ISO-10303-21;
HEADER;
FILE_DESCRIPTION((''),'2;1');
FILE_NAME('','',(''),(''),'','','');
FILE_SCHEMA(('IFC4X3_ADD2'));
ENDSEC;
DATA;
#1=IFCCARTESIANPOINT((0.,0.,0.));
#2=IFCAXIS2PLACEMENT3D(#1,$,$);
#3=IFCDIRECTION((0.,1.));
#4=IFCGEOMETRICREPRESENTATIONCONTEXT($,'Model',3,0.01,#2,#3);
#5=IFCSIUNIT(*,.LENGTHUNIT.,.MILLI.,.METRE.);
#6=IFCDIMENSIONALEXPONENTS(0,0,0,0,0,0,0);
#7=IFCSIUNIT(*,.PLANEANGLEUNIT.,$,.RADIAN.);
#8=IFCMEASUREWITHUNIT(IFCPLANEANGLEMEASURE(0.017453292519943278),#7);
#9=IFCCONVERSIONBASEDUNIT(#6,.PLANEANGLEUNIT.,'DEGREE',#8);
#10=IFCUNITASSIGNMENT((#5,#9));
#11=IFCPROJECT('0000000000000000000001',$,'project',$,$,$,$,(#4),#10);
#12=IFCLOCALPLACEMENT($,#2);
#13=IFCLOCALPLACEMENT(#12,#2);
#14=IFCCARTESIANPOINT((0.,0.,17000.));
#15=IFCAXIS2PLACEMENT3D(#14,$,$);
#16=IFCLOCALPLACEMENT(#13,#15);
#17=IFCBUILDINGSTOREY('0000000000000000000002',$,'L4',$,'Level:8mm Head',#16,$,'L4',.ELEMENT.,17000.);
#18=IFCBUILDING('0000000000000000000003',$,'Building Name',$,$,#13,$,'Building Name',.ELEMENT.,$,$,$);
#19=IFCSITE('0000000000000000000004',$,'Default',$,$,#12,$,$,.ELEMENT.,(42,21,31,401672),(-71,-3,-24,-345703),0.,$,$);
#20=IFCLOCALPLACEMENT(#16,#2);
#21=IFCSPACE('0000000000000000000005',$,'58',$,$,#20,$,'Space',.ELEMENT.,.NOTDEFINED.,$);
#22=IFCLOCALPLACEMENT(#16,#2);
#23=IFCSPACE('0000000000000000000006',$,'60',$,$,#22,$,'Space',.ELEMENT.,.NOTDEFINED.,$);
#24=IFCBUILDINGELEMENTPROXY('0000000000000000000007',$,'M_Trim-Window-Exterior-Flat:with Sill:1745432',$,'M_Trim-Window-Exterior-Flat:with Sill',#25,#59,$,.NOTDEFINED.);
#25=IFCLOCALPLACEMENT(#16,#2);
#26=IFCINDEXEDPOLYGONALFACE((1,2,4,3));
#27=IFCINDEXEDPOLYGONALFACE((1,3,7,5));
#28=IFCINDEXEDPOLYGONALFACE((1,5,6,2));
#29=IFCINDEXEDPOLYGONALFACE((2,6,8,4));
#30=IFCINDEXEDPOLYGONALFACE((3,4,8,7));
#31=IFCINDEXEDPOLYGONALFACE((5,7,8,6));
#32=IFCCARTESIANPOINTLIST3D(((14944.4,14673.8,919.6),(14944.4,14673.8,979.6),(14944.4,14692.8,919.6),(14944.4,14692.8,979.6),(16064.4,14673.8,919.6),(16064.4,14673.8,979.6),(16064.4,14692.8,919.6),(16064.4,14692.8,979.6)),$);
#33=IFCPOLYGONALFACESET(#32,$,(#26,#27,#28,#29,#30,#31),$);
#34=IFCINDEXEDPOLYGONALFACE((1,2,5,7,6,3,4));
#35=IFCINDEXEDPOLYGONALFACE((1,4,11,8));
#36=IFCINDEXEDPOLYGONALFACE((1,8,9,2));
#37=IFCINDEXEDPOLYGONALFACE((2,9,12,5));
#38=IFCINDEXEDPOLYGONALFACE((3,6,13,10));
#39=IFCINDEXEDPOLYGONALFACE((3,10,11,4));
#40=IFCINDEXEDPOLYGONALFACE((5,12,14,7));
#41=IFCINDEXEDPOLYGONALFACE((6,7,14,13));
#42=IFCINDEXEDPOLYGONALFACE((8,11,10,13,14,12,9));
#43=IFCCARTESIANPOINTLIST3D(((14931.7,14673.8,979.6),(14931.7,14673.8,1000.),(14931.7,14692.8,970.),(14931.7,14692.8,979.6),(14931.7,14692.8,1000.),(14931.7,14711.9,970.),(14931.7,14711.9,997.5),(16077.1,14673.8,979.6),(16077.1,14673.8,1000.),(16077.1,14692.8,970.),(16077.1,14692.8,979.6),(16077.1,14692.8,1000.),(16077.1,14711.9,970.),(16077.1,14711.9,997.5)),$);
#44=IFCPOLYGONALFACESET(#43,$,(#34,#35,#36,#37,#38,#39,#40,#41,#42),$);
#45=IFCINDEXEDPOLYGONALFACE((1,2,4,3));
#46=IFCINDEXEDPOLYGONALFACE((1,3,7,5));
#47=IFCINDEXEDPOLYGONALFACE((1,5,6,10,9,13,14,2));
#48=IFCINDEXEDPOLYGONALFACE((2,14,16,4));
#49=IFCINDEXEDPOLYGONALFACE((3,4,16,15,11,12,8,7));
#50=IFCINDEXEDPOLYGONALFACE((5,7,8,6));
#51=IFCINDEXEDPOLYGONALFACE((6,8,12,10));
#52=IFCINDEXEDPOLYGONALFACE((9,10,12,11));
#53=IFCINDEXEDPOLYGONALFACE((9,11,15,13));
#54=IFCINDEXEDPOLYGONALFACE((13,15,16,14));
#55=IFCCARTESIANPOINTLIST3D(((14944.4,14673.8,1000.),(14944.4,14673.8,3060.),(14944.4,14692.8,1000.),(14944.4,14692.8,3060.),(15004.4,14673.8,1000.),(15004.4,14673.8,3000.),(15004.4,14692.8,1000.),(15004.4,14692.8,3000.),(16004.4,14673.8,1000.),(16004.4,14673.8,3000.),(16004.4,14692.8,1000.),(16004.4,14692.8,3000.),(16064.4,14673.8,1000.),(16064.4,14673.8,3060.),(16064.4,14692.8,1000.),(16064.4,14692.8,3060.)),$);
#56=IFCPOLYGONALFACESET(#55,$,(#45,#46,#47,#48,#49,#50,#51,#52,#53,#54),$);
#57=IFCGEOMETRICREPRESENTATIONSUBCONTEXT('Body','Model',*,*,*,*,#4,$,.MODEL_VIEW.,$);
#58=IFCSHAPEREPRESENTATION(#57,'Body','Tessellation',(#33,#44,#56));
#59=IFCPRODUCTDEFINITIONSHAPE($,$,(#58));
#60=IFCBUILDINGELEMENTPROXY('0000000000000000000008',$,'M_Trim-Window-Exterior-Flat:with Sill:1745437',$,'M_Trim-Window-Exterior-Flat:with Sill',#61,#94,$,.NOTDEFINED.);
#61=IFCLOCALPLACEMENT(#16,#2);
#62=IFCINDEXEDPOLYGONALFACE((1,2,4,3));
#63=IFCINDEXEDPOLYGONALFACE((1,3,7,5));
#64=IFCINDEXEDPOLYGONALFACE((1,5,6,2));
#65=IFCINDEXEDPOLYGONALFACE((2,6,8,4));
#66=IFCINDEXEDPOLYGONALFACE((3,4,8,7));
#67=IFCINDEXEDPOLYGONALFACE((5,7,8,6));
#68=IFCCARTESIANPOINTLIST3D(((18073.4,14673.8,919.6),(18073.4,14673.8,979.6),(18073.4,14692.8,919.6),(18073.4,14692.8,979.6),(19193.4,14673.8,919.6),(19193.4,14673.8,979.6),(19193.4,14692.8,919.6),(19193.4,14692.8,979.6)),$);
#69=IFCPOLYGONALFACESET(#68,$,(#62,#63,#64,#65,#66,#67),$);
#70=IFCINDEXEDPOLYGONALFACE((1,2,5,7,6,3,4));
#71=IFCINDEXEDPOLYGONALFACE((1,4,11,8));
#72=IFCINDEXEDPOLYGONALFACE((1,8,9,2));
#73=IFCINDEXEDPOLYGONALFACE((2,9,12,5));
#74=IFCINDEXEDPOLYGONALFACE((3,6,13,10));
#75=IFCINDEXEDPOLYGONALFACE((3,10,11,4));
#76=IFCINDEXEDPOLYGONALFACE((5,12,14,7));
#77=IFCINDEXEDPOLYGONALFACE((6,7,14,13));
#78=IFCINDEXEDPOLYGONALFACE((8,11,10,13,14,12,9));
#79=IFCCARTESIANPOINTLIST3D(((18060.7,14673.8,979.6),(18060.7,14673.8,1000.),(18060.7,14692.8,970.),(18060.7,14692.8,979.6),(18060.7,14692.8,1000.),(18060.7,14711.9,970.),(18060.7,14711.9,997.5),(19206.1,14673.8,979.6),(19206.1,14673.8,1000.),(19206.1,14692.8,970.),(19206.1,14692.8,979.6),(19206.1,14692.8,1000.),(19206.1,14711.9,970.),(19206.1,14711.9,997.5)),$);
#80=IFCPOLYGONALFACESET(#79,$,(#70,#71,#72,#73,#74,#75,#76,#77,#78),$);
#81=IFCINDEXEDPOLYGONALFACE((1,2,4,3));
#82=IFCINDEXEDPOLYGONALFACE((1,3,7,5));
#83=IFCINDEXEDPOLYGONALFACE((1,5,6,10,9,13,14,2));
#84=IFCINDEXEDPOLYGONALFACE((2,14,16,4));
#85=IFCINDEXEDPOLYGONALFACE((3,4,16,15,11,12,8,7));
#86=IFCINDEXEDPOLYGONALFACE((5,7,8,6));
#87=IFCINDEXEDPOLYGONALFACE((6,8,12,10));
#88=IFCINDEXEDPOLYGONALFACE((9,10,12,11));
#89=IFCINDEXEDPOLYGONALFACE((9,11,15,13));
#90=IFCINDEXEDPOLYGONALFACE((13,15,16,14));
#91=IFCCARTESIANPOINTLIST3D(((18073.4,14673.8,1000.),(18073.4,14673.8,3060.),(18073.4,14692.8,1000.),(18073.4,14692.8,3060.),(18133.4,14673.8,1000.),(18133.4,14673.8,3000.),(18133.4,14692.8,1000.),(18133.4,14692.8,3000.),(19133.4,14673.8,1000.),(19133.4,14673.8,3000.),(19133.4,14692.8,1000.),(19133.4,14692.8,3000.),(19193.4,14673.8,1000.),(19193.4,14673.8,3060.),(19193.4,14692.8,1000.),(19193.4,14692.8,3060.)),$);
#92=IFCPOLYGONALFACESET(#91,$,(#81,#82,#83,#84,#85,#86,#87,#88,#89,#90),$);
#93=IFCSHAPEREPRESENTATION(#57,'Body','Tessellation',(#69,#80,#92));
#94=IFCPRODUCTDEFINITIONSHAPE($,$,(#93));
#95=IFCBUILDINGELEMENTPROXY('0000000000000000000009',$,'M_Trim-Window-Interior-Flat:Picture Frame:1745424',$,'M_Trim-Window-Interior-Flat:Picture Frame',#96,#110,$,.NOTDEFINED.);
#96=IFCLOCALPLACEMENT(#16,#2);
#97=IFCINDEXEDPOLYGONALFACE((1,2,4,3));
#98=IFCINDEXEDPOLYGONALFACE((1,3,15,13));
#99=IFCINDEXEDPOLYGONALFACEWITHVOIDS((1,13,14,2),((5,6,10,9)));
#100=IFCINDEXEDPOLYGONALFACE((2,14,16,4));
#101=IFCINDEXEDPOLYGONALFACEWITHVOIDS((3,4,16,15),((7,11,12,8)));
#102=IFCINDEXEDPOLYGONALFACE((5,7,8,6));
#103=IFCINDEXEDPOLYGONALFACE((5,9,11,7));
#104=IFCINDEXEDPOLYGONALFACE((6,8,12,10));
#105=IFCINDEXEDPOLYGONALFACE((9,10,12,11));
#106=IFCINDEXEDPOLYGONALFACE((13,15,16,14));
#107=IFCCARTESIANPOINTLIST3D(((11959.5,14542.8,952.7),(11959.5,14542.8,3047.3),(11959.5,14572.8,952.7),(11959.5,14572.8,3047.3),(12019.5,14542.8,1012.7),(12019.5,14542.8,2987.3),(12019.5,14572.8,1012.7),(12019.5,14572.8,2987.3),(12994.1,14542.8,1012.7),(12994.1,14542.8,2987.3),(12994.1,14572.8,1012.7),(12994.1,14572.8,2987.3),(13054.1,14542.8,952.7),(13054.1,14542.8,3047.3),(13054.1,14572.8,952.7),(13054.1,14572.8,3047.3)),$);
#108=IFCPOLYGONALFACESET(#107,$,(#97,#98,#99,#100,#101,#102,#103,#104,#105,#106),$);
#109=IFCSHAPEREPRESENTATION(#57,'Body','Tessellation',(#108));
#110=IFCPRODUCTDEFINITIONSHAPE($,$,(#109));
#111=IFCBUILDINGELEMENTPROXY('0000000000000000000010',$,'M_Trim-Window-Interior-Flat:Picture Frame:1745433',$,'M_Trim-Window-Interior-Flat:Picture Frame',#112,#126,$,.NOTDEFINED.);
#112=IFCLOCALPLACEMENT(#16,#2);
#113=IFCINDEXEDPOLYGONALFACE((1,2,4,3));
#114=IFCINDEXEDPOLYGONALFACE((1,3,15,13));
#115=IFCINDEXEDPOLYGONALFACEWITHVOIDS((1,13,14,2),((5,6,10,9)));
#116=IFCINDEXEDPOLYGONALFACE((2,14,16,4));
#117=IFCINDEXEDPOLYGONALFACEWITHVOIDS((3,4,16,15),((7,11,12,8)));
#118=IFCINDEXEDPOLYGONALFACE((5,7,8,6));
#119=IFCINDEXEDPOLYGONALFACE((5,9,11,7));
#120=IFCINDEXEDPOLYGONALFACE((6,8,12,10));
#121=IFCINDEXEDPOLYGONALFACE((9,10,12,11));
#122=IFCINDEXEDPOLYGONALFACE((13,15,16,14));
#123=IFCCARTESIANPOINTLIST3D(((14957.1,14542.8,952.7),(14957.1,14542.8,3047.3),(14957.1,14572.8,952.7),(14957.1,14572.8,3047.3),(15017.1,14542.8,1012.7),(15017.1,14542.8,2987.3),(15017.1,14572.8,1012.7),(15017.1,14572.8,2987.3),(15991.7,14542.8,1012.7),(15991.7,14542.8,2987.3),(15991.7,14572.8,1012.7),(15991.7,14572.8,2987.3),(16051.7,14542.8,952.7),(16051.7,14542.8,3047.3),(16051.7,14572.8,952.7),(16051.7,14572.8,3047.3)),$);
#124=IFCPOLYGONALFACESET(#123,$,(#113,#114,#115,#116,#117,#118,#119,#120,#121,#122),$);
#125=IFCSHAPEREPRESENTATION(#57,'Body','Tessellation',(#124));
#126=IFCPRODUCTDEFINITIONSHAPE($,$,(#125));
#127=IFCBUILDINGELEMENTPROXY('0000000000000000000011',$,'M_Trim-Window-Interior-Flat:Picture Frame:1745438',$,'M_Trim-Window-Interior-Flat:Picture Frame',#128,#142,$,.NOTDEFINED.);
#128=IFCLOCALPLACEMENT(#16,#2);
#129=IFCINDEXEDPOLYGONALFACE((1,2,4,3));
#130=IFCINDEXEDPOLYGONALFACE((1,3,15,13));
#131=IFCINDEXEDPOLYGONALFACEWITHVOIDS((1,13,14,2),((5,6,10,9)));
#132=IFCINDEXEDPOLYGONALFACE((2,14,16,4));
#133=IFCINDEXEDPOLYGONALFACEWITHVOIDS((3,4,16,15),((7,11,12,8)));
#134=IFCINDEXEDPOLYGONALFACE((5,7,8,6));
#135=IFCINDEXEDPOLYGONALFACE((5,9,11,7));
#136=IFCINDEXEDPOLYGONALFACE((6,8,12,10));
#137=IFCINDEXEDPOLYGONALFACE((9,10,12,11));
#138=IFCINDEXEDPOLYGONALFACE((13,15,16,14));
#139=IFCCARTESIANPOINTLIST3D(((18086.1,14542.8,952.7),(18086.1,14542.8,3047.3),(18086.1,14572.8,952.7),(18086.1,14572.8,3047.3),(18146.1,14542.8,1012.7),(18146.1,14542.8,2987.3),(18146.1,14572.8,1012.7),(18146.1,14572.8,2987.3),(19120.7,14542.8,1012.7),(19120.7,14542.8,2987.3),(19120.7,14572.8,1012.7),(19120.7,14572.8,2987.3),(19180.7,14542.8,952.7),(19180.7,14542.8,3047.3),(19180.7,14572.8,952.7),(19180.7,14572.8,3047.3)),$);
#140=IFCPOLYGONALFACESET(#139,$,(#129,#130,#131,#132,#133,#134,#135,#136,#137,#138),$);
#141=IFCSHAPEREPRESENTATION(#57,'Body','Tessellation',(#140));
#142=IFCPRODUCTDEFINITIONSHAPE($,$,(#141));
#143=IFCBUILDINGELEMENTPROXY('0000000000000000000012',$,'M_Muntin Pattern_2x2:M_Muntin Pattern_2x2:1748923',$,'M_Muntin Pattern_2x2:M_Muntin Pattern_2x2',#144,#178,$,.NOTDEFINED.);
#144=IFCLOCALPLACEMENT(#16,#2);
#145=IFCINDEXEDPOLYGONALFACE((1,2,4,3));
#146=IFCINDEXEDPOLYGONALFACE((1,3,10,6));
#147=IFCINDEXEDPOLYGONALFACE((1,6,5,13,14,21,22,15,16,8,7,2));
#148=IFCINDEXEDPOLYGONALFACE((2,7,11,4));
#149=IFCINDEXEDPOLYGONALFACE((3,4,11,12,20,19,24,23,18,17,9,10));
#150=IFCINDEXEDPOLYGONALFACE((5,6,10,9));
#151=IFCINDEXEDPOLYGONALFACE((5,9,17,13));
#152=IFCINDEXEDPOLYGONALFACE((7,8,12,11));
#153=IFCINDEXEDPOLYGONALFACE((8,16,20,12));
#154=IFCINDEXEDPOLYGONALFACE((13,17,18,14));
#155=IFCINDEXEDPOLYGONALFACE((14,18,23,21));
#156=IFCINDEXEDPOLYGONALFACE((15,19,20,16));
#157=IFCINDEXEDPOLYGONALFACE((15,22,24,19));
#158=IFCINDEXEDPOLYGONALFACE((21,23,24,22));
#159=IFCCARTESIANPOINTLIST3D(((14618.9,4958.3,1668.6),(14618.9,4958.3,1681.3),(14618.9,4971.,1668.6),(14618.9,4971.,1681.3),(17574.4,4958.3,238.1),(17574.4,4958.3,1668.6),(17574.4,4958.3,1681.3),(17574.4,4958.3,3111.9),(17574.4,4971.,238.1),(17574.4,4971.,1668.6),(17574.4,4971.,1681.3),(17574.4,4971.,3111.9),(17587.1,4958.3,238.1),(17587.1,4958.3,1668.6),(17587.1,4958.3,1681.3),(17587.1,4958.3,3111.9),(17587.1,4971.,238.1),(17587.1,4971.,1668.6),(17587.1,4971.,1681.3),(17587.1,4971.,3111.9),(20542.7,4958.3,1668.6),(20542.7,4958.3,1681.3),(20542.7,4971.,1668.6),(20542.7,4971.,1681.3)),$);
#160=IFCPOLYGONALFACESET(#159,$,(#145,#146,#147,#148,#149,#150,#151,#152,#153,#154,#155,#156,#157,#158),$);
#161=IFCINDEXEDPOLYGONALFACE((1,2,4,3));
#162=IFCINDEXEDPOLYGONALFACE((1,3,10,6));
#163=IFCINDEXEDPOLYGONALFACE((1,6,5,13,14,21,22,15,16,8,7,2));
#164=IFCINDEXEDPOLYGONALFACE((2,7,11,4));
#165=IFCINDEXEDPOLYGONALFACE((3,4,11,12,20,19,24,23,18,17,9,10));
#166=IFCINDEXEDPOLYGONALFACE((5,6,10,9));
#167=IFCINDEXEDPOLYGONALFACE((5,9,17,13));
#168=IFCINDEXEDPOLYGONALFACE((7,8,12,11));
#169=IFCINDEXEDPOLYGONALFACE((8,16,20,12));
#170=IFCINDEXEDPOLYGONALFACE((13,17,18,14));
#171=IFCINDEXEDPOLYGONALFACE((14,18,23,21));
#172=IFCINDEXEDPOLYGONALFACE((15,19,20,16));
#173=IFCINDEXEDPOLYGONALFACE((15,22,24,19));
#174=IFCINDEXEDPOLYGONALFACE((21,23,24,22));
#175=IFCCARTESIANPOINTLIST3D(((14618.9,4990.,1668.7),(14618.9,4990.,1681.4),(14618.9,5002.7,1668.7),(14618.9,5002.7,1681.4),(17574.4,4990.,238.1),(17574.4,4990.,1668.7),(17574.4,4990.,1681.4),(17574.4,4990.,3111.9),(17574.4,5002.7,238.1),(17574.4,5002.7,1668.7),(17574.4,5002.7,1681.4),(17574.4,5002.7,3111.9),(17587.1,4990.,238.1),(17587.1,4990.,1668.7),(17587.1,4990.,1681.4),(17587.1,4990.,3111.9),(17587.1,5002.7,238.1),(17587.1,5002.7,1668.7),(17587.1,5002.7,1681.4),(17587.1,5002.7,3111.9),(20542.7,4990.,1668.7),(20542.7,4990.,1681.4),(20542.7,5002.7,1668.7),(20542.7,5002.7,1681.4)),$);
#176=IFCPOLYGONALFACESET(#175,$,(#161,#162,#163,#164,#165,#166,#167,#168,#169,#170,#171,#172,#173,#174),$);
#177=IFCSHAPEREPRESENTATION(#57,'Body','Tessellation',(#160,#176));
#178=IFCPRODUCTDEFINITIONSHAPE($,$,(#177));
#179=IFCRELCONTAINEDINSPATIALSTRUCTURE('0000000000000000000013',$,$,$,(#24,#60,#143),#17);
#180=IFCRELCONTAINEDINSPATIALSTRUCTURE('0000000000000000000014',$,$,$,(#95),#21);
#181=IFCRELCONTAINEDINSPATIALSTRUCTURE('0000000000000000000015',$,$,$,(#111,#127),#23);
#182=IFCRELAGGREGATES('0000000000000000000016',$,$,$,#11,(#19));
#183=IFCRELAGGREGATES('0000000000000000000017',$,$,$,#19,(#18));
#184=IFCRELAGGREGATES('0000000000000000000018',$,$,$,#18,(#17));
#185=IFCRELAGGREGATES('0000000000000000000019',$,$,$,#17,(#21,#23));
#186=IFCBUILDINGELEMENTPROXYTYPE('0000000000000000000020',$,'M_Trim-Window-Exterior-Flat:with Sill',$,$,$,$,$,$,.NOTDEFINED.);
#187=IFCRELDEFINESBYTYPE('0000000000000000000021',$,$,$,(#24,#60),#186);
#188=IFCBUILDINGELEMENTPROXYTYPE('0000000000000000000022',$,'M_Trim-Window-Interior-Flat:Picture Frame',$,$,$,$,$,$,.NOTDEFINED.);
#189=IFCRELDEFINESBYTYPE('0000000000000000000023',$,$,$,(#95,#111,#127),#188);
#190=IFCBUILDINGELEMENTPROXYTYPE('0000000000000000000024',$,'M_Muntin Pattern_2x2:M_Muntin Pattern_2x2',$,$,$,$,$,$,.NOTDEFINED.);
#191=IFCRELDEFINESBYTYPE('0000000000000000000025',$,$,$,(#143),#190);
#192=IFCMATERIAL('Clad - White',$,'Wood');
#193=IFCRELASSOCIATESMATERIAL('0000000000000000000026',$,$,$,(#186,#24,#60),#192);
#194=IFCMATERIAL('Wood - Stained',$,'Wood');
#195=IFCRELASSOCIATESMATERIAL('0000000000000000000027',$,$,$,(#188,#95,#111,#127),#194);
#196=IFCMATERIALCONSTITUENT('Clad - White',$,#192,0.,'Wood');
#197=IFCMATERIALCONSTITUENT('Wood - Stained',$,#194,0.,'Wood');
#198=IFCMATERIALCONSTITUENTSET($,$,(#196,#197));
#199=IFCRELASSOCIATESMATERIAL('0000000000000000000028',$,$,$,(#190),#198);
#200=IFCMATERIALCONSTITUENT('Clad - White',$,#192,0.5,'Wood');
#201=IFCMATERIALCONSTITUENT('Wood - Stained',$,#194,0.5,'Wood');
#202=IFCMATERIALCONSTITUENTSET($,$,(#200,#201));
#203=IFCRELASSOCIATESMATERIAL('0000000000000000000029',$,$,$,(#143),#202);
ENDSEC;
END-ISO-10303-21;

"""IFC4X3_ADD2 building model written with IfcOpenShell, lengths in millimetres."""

from ifc_helpers import new_model, entity, si_unit, converted_unit, direction, frame, frame_2d, origin, place, context, subcontext, project, spatial, polyline, rectangle, outline, extrude, source, transform, mapped, material, constituent, constituent_set, type_object, type_shapes, element, save


model = new_model("IFC4X3_ADD2")

# Units and contexts
model_context = context("Model", 3, precision=0.01, world=origin(), true_north=direction((0.0, 1.0)))
body_context = subcontext(model_context, "Body", "Model", "MODEL_VIEW")
ifc_project = project(units=[si_unit("LENGTHUNIT", "METRE", prefix="MILLI"), converted_unit("PLANEANGLEUNIT", "DEGREE", entity("IfcPlaneAngleMeasure", 0.017453292519943278), si_unit("PLANEANGLEUNIT", "RADIAN"), dimensions=[0, 0, 0, 0, 0, 0, 0])], contexts=[model_context])

# Site, building, storey
site_placement = place(None, origin())
site = spatial("IfcSite", under=ifc_project, at=site_placement, Name="Default", CompositionType="ELEMENT", RefLatitude=(42, 21, 31, 401672), RefLongitude=(-71, -3, -24, -345703), RefElevation=0.0)
building_placement = place(site_placement, origin())
building = spatial("IfcBuilding", under=site, at=building_placement, Name="Building Name", LongName="Building Name", CompositionType="ELEMENT")
storey_placement = place(building_placement, frame((0.0, 0.0, 17000.0)))
storey = spatial("IfcBuildingStorey", under=building, at=storey_placement, Name="L4", ObjectType="Level:8mm Head", LongName="L4", CompositionType="ELEMENT", Elevation=17000.0)

# Building element proxies
ifc_material_1 = material(Name="Clad - White", Category="Wood")
ifc_material_2 = material(Name="Wood - Stained", Category="Wood")
building_element_proxy_type_1 = type_object("IfcBuildingElementProxyType", Name="M_Trim-Window-Exterior-Flat:with Sill", PredefinedType="NOTDEFINED", material=ifc_material_1)
shared_shape_1 = source(origin(), body_context, "Body", "SweptSolid", [
    extrude(rectangle(XDim=1120.0, YDim=60.0, at=frame_2d((0.0, 0.0), x_axis=(1.0, 0.0))), frame((0.0, -2050.4, 0.0), z_axis=(0.0, 0.0, 1.0), x_axis=(-1.0, 0.0, 0.0)), (0.0, 0.0, 1.0), 19.0),
    extrude(outline(polyline([(-19.0, -15.2), (0.0, -15.2), (0.0, -5.7), (19.0, -5.7), (19.0, 14.8), (0.0, 14.8), (-19.0, 12.3), (-19.0, -15.2)])), frame((-572.7, -2014.8, 19.0), z_axis=(1.0, 0.0, 0.0), x_axis=(0.0, 0.0, -1.0)), (0.0, 0.0, 1.0), 1145.4),
    extrude(outline(polyline([(-1045.0, -560.0), (1015.0, -560.0), (1015.0, -500.0), (-985.0, -500.0), (-985.0, 500.0), (1015.0, 500.0), (1015.0, 560.0), (-1045.0, 560.0), (-1045.0, -560.0)])), frame((0.0, -985.0, 0.0), z_axis=(0.0, 0.0, 1.0), x_axis=(0.0, -1.0, 0.0)), (0.0, 0.0, 1.0), 19.0),
])
type_shapes(building_element_proxy_type_1, [shared_shape_1])
for number, where, z_axis, x_axis, name in (
    (1, (15504.4, 14673.8, 3000.0), (0.0, 1.0, 0.0), (-1.0, 0.0, 0.0), "M_Trim-Window-Exterior-Flat:with Sill:1745432"),
    (2, (18633.4, 14673.8, 3000.0), (0.0, 1.0, 0.0), (-1.0, 0.0, 0.0), "M_Trim-Window-Exterior-Flat:with Sill:1745437"),
):
    element("IfcBuildingElementProxy", number, at=place(storey_placement, frame(where, z_axis=z_axis, x_axis=x_axis)), inside=storey, type_object=building_element_proxy_type_1, material=ifc_material_1, Name=name, ObjectType="M_Trim-Window-Exterior-Flat:with Sill", PredefinedType="NOTDEFINED", context=body_context, shape_type="MappedRepresentation", body=[
        mapped(shared_shape_1, transform((0.0, 0.0, 0.0), scale=1.0)),
    ])

# Shared definitions
space_1_placement = place(storey_placement, origin())
space_1 = spatial("IfcSpace", under=storey, at=space_1_placement, Name="58", LongName="Space", CompositionType="ELEMENT", PredefinedType="NOTDEFINED")

# Building element proxy
building_element_proxy_type_2 = type_object("IfcBuildingElementProxyType", Name="M_Trim-Window-Interior-Flat:Picture Frame", PredefinedType="NOTDEFINED", material=ifc_material_2)
shared_shape_2 = source(origin(), body_context, "Body", "SweptSolid", [
    extrude(outline(polyline([(-547.3, -1047.3), (547.3, -1047.3), (547.3, 1047.3), (-547.3, 1047.3), (-547.3, -1047.3)]), holes=[polyline([(-487.3, -987.3), (-487.3, 987.3), (487.3, 987.3), (487.3, -987.3), (-487.3, -987.3)])]), frame((0.0, -1000.0, 0.0), z_axis=(0.0, 0.0, 1.0), x_axis=(-1.0, 0.0, 0.0)), (0.0, 0.0, 1.0), 30.0),
])
type_shapes(building_element_proxy_type_2, [shared_shape_2])
proxy_1_placement = place(space_1_placement, frame((12506.8, 14572.8, 3000.0), z_axis=(0.0, -1.0, 0.0), x_axis=(1.0, 0.0, 0.0)))
element("IfcBuildingElementProxy", 3, at=proxy_1_placement, inside=space_1, type_object=building_element_proxy_type_2, material=ifc_material_2, Name="M_Trim-Window-Interior-Flat:Picture Frame:1745424", ObjectType="M_Trim-Window-Interior-Flat:Picture Frame", PredefinedType="NOTDEFINED", context=body_context, shape_type="MappedRepresentation", body=[
    mapped(shared_shape_2, transform((0.0, 0.0, 0.0), scale=1.0)),
])

# Shared definitions
space_2_placement = place(storey_placement, origin())
space_2 = spatial("IfcSpace", under=storey, at=space_2_placement, Name="60", LongName="Space", CompositionType="ELEMENT", PredefinedType="NOTDEFINED")

# Building element proxies
for number, where, z_axis, x_axis, name in (
    (4, (15504.4, 14572.8, 3000.0), (0.0, -1.0, 0.0), (1.0, 0.0, 0.0), "M_Trim-Window-Interior-Flat:Picture Frame:1745433"),
    (5, (18633.4, 14572.8, 3000.0), (0.0, -1.0, 0.0), (1.0, 0.0, 0.0), "M_Trim-Window-Interior-Flat:Picture Frame:1745438"),
):
    element("IfcBuildingElementProxy", number, at=place(space_2_placement, frame(where, z_axis=z_axis, x_axis=x_axis)), inside=space_2, type_object=building_element_proxy_type_2, material=ifc_material_2, Name=name, ObjectType="M_Trim-Window-Interior-Flat:Picture Frame", PredefinedType="NOTDEFINED", context=body_context, shape_type="MappedRepresentation", body=[
        mapped(shared_shape_2, transform((0.0, 0.0, 0.0), scale=1.0)),
    ])
ifc_constituent_1 = constituent(ifc_material_1, Name="Clad - White", Category="Wood", fraction=0.5)
ifc_constituent_2 = constituent(ifc_material_2, Name="Wood - Stained", Category="Wood", fraction=0.5)
ifc_constituent_set_1 = constituent_set(constituents=[ifc_constituent_1, ifc_constituent_2])
ifc_constituent_3 = constituent(ifc_material_1, Name="Clad - White", Category="Wood", fraction=0.0)
ifc_constituent_4 = constituent(ifc_material_2, Name="Wood - Stained", Category="Wood", fraction=0.0)
ifc_constituent_set_2 = constituent_set(constituents=[ifc_constituent_3, ifc_constituent_4])
building_element_proxy_type_3 = type_object("IfcBuildingElementProxyType", Name="M_Muntin Pattern_2x2:M_Muntin Pattern_2x2", PredefinedType="NOTDEFINED", material=ifc_constituent_set_2)
shared_shape_3 = source(origin(), body_context, "Body", "SweptSolid", [
    extrude(outline(polyline([(6.4, -6.4), (1436.9, -6.4), (1436.9, 6.3), (6.4, 6.3), (6.4, 2961.9), (-6.3, 2961.9), (-6.3, 6.3), (-1436.9, 6.3), (-1436.9, -6.4), (-6.3, -6.4), (-6.3, -2961.9), (6.4, -2961.9), (6.4, -6.4)])), frame((0.0, -22.2, 1436.9), z_axis=(0.0, 1.0, 0.0), x_axis=(0.0, 0.0, 1.0)), (0.0, 0.0, 1.0), 12.7),
    extrude(outline(polyline([(6.4, -6.4), (1436.9, -6.4), (1436.9, 6.3), (6.4, 6.3), (6.4, 2961.9), (-6.3, 2961.9), (-6.3, 6.3), (-1436.9, 6.3), (-1436.9, -6.4), (-6.3, -6.4), (-6.3, -2961.9), (6.4, -2961.9), (6.4, -6.4)])), frame((0.0, 9.5, 1436.9), z_axis=(0.0, 1.0, 0.0), x_axis=(0.0, 0.0, 1.0)), (0.0, 0.0, 1.0), 12.7),
])
type_shapes(building_element_proxy_type_3, [shared_shape_3])
proxy_2_placement = place(storey_placement, frame((17580.8, 4980.5, 238.1)))
element("IfcBuildingElementProxy", 6, at=proxy_2_placement, inside=storey, type_object=building_element_proxy_type_3, material=ifc_constituent_set_1, Name="M_Muntin Pattern_2x2:M_Muntin Pattern_2x2:1748923", ObjectType="M_Muntin Pattern_2x2:M_Muntin Pattern_2x2", PredefinedType="NOTDEFINED", context=body_context, shape_type="MappedRepresentation", body=[
    mapped(shared_shape_3, transform((0.0, 0.0, 0.0), scale=1.0)),
])

save(model, "model.ifc")
